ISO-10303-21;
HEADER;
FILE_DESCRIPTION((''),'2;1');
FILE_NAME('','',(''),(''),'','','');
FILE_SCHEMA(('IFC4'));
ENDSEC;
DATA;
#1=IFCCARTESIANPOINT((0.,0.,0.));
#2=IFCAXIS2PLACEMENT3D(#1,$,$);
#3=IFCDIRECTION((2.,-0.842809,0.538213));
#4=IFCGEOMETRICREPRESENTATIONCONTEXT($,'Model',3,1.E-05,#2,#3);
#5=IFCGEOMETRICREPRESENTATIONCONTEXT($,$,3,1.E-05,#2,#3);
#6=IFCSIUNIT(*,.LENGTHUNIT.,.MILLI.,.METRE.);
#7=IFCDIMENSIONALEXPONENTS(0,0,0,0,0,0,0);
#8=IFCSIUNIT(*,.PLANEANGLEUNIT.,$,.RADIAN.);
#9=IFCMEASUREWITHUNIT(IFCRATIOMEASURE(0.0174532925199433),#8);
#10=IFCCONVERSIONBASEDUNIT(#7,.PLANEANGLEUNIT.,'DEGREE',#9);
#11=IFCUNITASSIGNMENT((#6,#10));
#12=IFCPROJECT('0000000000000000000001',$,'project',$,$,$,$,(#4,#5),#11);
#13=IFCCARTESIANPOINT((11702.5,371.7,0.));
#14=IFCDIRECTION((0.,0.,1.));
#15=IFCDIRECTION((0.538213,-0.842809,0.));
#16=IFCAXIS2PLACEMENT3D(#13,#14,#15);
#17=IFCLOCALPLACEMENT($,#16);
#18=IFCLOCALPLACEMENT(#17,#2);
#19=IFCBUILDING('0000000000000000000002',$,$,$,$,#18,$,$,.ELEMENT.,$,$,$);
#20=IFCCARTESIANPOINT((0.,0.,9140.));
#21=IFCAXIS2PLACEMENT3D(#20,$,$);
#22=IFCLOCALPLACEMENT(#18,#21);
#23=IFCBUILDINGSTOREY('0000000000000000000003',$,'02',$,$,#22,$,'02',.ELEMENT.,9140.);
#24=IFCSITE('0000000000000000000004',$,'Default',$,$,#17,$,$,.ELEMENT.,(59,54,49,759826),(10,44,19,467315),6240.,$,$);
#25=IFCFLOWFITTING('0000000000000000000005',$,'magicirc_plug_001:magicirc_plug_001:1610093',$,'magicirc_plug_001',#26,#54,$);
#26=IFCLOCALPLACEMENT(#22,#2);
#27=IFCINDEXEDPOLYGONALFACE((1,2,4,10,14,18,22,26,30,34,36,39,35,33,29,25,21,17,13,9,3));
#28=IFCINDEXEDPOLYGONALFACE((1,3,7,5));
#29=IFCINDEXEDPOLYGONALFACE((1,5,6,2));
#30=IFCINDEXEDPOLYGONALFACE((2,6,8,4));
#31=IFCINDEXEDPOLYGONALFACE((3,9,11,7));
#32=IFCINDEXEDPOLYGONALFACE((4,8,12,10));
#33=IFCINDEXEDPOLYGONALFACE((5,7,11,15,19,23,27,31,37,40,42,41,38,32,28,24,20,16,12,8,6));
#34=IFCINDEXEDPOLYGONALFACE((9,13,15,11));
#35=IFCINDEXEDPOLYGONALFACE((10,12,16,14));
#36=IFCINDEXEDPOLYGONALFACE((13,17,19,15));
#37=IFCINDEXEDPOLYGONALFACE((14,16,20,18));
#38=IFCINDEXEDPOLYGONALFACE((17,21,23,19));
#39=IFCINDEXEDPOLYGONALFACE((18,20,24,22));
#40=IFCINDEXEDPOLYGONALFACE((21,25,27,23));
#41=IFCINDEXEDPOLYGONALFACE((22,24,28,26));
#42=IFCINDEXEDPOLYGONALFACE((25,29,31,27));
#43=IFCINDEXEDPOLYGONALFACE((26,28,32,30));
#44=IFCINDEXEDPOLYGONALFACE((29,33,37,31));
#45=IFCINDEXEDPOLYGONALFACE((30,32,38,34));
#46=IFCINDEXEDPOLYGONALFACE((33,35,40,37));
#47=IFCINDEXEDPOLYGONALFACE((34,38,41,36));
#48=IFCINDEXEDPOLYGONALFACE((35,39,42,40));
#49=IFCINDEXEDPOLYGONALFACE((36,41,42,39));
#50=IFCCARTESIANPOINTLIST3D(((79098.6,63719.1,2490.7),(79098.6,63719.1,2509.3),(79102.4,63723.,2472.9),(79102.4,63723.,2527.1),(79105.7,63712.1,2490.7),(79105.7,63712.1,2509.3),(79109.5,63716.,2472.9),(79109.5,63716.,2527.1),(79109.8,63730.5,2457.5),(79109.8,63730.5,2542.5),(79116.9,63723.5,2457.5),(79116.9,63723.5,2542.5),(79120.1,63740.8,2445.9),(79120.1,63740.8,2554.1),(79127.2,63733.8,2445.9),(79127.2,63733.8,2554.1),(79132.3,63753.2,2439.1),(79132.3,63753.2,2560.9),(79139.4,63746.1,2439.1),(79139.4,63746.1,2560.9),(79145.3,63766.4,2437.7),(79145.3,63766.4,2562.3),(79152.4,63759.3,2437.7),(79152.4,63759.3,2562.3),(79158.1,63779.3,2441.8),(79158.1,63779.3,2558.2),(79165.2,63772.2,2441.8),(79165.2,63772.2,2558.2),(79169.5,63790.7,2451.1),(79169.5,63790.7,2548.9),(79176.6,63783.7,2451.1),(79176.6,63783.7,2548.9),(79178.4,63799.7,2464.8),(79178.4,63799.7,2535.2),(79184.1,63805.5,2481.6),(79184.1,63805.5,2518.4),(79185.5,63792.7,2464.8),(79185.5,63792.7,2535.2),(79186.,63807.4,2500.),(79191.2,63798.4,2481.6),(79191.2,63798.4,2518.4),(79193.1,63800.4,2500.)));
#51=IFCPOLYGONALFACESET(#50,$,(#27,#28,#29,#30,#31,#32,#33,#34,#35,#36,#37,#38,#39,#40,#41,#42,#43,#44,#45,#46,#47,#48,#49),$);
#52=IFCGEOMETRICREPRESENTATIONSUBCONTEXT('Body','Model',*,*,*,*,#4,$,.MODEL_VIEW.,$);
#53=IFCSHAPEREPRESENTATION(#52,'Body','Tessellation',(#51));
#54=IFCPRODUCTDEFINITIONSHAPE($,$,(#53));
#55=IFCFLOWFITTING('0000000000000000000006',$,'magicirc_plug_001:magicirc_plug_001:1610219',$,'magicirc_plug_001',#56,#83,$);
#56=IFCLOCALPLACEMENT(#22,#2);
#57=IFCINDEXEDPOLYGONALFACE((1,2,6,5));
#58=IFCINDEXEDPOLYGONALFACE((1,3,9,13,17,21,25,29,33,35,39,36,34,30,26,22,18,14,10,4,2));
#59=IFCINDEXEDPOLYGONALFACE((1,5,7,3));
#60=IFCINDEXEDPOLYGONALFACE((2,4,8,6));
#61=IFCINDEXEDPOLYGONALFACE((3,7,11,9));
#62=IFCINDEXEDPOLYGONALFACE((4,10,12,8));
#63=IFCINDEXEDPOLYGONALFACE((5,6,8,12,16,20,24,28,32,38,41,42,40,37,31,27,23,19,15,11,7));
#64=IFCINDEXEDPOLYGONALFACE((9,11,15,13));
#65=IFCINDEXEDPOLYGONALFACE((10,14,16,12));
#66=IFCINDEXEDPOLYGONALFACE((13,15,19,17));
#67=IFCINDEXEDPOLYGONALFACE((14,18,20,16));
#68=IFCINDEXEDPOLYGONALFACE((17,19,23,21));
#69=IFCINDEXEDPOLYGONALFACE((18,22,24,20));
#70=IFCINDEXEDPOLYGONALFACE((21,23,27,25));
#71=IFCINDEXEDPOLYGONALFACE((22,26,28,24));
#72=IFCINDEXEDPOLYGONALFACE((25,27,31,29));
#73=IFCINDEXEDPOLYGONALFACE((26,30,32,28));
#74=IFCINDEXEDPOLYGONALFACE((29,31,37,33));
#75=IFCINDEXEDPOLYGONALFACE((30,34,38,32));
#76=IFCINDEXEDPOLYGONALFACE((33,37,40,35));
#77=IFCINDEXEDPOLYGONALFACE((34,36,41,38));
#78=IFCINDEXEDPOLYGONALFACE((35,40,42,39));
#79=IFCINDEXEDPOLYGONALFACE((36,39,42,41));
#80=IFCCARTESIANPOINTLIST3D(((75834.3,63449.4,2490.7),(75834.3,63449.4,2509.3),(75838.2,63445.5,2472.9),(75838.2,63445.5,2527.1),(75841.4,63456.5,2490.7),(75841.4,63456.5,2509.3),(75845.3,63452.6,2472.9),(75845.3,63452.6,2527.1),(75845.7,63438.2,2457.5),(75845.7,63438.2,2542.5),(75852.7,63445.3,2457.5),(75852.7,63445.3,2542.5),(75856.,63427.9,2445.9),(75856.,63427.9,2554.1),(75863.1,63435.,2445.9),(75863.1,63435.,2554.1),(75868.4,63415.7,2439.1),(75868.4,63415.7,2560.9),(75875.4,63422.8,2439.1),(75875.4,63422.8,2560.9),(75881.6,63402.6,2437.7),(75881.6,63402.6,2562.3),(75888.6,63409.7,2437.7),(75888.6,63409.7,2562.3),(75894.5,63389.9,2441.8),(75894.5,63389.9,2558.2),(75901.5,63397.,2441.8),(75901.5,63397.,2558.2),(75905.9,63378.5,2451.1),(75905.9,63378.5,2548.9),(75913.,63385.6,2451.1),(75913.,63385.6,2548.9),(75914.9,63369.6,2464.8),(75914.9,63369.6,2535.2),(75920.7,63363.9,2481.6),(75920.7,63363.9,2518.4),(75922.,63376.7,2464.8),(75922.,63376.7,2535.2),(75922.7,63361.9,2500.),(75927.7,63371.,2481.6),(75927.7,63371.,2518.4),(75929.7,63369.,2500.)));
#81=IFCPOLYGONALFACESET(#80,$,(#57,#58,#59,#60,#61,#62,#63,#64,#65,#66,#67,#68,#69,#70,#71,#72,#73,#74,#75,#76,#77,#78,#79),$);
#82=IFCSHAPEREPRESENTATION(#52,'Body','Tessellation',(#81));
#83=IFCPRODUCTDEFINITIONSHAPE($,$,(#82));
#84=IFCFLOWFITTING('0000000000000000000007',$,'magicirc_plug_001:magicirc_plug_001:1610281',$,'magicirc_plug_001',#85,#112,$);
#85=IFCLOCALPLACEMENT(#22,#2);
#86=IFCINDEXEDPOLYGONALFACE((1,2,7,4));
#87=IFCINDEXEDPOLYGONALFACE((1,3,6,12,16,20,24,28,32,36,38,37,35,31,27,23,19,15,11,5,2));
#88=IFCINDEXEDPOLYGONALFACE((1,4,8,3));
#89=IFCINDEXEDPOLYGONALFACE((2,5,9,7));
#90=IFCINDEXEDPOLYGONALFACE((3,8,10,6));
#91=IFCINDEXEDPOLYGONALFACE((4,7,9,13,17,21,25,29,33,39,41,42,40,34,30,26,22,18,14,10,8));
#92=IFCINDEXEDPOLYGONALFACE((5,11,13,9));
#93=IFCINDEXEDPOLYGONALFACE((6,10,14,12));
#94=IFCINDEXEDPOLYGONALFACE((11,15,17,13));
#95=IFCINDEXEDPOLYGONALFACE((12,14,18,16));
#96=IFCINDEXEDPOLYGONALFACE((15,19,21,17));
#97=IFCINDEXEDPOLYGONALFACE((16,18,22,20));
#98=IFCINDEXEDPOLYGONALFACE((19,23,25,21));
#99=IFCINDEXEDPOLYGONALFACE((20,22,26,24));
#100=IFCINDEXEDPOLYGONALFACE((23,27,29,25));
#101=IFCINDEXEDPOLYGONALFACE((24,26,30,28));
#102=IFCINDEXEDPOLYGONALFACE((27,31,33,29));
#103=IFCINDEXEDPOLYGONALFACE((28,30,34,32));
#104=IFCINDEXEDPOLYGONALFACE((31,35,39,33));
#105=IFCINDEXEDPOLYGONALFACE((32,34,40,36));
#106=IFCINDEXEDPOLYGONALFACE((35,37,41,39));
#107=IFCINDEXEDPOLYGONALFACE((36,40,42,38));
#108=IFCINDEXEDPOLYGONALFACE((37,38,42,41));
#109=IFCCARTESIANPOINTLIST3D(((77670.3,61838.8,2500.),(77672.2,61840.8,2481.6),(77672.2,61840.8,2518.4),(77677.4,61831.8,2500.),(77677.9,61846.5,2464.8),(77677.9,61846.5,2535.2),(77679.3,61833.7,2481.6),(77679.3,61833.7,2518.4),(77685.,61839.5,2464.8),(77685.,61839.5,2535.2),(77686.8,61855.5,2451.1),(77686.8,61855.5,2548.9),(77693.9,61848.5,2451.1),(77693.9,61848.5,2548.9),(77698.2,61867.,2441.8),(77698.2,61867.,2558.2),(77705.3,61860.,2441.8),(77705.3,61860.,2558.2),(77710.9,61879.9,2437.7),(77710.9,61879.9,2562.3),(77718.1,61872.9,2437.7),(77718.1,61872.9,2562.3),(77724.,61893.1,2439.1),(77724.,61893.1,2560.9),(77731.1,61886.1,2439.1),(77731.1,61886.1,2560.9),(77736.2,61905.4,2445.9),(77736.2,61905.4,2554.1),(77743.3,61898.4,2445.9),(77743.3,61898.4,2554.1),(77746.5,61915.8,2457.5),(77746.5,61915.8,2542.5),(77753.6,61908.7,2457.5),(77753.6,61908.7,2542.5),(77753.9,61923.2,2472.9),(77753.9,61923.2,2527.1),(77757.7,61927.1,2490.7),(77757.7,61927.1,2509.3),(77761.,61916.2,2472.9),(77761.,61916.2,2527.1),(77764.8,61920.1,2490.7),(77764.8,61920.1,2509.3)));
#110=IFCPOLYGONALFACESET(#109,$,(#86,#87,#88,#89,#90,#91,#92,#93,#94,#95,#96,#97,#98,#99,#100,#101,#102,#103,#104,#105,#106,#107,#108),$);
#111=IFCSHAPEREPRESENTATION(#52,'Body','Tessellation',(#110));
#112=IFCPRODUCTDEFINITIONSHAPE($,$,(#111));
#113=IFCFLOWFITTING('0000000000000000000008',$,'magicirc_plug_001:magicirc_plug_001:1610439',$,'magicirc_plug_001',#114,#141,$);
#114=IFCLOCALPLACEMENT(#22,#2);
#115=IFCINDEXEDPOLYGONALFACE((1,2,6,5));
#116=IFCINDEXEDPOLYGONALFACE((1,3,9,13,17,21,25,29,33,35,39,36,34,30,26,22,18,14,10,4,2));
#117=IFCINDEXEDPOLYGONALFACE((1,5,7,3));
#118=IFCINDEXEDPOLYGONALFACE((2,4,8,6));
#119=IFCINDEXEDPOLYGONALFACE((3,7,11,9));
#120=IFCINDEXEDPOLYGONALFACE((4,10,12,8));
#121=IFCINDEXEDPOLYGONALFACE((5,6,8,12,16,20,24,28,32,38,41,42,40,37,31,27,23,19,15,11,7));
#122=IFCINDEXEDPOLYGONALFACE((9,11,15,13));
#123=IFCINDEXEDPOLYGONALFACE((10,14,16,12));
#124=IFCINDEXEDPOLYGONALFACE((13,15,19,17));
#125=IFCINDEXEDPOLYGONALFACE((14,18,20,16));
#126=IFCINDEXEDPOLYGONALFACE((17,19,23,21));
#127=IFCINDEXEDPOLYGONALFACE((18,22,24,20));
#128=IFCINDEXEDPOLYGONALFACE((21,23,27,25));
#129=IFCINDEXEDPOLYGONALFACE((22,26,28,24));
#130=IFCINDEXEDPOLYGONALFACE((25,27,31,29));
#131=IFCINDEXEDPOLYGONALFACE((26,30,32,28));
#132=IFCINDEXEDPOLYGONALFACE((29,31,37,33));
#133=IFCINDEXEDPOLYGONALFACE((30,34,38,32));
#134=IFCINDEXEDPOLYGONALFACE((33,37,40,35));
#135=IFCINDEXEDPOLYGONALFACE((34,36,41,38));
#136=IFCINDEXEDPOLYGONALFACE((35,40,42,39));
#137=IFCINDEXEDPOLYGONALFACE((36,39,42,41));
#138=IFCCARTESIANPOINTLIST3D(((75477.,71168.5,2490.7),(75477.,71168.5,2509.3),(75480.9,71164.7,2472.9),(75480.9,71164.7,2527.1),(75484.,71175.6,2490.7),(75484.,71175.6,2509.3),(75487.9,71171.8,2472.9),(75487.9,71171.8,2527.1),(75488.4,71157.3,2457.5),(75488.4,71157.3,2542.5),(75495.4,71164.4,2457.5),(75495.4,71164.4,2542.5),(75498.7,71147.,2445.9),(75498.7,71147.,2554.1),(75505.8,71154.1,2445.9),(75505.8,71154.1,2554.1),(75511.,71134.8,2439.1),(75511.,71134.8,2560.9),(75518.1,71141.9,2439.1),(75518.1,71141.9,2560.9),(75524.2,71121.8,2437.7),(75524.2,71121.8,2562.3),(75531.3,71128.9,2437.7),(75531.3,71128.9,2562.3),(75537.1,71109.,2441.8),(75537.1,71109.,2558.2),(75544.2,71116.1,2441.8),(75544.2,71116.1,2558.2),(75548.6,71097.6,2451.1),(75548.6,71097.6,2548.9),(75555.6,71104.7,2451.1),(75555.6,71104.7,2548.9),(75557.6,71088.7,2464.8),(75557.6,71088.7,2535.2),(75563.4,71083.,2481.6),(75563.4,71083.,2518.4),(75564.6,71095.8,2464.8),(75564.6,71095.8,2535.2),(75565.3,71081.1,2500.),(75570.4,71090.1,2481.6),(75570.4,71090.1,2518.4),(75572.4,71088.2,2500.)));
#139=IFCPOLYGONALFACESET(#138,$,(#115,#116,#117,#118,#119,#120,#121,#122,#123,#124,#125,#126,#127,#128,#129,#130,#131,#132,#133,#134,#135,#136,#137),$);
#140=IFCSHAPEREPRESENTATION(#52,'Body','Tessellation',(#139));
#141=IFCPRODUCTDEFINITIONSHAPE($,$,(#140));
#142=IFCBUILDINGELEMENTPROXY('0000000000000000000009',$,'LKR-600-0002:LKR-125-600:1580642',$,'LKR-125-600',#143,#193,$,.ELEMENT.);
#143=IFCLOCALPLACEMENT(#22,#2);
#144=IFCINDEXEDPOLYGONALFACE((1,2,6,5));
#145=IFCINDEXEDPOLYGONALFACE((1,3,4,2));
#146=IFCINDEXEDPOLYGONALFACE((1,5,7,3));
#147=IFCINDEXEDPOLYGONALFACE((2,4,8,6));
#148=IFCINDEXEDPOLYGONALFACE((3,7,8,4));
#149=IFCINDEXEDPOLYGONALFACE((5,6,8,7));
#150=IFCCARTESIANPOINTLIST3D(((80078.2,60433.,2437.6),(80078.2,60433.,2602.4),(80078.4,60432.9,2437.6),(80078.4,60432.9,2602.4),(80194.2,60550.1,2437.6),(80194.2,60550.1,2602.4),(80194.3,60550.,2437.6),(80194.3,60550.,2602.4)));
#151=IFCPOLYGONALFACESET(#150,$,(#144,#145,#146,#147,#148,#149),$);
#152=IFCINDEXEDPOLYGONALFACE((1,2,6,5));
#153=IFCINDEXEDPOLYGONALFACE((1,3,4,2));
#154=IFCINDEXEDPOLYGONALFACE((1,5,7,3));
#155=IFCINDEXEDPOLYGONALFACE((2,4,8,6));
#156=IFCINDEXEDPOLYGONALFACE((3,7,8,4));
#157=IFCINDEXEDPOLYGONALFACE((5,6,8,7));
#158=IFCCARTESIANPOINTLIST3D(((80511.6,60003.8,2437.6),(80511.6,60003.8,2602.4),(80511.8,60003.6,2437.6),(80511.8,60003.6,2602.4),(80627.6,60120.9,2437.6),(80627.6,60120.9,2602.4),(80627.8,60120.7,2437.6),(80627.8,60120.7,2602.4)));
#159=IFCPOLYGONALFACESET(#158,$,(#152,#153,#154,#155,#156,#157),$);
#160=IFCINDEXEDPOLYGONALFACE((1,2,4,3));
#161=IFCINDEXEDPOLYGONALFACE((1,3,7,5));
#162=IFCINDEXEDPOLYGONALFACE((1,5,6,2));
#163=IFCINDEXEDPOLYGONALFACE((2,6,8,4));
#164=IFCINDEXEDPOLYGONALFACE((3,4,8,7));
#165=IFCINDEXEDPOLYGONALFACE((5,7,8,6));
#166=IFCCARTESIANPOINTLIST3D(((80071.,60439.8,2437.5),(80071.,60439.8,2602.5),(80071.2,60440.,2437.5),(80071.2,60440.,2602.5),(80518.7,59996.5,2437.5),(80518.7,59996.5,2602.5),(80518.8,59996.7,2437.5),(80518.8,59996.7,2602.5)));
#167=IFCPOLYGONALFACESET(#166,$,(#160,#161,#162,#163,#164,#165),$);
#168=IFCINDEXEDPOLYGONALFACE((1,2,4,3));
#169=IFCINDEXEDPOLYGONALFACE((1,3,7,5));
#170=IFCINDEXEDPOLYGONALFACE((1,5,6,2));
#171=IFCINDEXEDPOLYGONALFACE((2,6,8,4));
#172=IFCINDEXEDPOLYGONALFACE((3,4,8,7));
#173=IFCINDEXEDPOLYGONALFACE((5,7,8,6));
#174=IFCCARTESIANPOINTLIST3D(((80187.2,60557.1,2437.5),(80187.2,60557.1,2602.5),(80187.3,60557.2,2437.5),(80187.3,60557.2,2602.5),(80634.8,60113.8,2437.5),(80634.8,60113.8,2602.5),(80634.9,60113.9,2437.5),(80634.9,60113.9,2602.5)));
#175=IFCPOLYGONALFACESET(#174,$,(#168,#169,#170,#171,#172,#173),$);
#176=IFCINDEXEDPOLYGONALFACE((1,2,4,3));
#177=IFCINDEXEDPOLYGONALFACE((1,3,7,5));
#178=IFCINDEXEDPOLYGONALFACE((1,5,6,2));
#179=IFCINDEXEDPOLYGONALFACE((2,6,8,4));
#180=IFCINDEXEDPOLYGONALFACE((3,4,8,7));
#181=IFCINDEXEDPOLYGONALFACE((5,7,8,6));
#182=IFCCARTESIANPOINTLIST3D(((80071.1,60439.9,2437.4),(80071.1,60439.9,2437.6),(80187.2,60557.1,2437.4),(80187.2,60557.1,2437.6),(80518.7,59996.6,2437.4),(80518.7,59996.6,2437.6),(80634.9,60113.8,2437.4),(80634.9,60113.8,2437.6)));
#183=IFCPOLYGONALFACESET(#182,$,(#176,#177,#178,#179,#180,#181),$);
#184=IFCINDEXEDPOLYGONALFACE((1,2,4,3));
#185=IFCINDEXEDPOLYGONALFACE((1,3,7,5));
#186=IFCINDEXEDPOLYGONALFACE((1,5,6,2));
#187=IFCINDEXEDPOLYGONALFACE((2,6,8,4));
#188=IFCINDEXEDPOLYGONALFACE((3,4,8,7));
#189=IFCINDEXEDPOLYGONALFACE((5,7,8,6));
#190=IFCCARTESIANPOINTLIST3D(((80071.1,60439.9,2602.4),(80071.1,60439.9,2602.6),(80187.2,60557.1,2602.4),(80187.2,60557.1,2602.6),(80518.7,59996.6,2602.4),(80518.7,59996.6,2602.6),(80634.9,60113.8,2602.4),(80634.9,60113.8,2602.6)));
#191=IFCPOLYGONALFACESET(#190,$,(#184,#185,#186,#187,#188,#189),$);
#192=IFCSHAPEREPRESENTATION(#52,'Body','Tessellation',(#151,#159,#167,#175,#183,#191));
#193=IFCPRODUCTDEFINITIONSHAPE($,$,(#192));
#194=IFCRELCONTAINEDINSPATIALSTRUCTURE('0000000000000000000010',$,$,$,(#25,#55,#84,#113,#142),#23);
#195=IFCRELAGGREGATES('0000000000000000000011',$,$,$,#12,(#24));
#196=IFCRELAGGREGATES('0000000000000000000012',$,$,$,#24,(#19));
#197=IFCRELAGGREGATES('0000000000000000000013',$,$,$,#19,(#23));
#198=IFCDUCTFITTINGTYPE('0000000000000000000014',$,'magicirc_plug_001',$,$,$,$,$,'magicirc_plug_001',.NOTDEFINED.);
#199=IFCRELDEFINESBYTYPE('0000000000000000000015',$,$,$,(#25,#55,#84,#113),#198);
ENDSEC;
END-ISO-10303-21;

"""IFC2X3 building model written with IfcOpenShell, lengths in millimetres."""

from ifc_helpers import new_model, entity, si_unit, converted_unit, direction, frame, frame_2d, origin, place, context, subcontext, project, spatial, rectangle, circle, extrude, source, transform, mapped, type_object, type_shapes, element, save


model = new_model("IFC2X3")

# Units and contexts
model_context = context("Model", 3, precision=1e-05, world=origin(), true_north=direction((2.0, -0.842809, 0.538213)))
context_of_model = context(None, 3, precision=1e-05, world=origin(), true_north=direction((2.0, -0.842809, 0.538213)))
body_context = subcontext(model_context, "Body", "Model", "MODEL_VIEW")
ifc_project = project(units=[si_unit("LENGTHUNIT", "METRE", prefix="MILLI"), converted_unit("PLANEANGLEUNIT", "DEGREE", entity("IfcRatioMeasure", 0.0174532925199433), si_unit("PLANEANGLEUNIT", "RADIAN"), dimensions=[0, 0, 0, 0, 0, 0, 0])], contexts=[model_context, context_of_model])

# Site, building, storey
site_placement = place(None, frame((11702.5, 371.7, 0.0), z_axis=(0.0, 0.0, 1.0), x_axis=(0.538213, -0.842809, 0.0)))
site = spatial("IfcSite", under=ifc_project, at=site_placement, Name="Default", CompositionType="ELEMENT", RefLatitude=(59, 54, 49, 759826), RefLongitude=(10, 44, 19, 467315), RefElevation=6240.0)
building_placement = place(site_placement, origin())
building = spatial("IfcBuilding", under=site, at=building_placement, CompositionType="ELEMENT")
storey_placement = place(building_placement, frame((0.0, 0.0, 9140.0)))
storey = spatial("IfcBuildingStorey", under=building, at=storey_placement, Name="02", LongName="02", CompositionType="ELEMENT", Elevation=9140.0)

# Flow fittings
duct_fitting_type_1 = type_object("IfcDuctFittingType", Name="magicirc_plug_001", ElementType="magicirc_plug_001", PredefinedType="NOTDEFINED")
shared_shape_1 = source(origin(), body_context, "Body", "SweptSolid", [
    extrude(circle(Radius=62.5, at=frame_2d((0.0, 0.0), x_axis=(1.0, 0.0))), frame((0.0, 0.0, 0.0), z_axis=(1.0, 0.0, 0.0), x_axis=(0.0, 1.0, 0.0)), (0.0, 0.0, 1.0), 10.0),
])
type_shapes(duct_fitting_type_1, [shared_shape_1])
for number, where, z_axis, x_axis, name in (
    (1, (79142.1, 63763.0, 2500.0), (0.0, 0.0, 1.0), (0.710528, -0.703669, 0.0), "magicirc_plug_001:magicirc_plug_001:1610093"),
    (2, (75885.3, 63413.0, 2500.0), (0.0, 0.0, 1.0), (-0.703669, -0.710528, 0.0), "magicirc_plug_001:magicirc_plug_001:1610219"),
    (3, (77721.3, 61876.2, 2500.0), (0.0, 0.0, 1.0), (-0.710528, 0.703669, 0.0), "magicirc_plug_001:magicirc_plug_001:1610281"),
    (4, (75528.0, 71132.2, 2500.0), (0.0, 0.0, 1.0), (-0.703669, -0.710528, 0.0), "magicirc_plug_001:magicirc_plug_001:1610439"),
):
    element("IfcFlowFitting", number, at=place(storey_placement, frame(where, z_axis=z_axis, x_axis=x_axis)), inside=storey, type_object=duct_fitting_type_1, Name=name, ObjectType="magicirc_plug_001", context=body_context, shape_type="MappedRepresentation", body=[
        mapped(shared_shape_1, transform((0.0, 0.0, 0.0), scale=1.0)),
    ])

# Building element proxy
shared_shape_2 = source(origin(), body_context, "Body", "SweptSolid", [
    extrude(rectangle(XDim=0.2, YDim=164.8, at=frame_2d((0.0, 0.0), x_axis=(1.0, 0.0))), frame((305.0, 0.0, -82.4)), (0.0, 0.0, 1.0), 164.8),
    extrude(rectangle(XDim=0.2, YDim=164.8, at=frame_2d((0.0, 0.0), x_axis=(1.0, 0.0))), frame((-305.0, 0.0, -82.4)), (0.0, 0.0, 1.0), 164.8),
    extrude(rectangle(XDim=0.2, YDim=630.0, at=frame_2d((0.0, 0.0), x_axis=(1.0, 0.0))), frame((0.0, 82.5, -82.5), z_axis=(0.0, 0.0, 1.0), x_axis=(0.0, 1.0, 0.0)), (0.0, 0.0, 1.0), 165.0),
    extrude(rectangle(XDim=0.2, YDim=630.0, at=frame_2d((0.0, 0.0), x_axis=(1.0, 0.0))), frame((0.0, -82.5, -82.5), z_axis=(0.0, 0.0, 1.0), x_axis=(0.0, 1.0, 0.0)), (0.0, 0.0, 1.0), 165.0),
    extrude(rectangle(XDim=165.0, YDim=630.0, at=frame_2d((0.0, 0.0), x_axis=(1.0, 0.0))), frame((0.0, 0.0, -82.6), z_axis=(0.0, 0.0, 1.0), x_axis=(0.0, -1.0, 0.0)), (0.0, 0.0, 1.0), 0.2),
    extrude(rectangle(XDim=165.0, YDim=630.0, at=frame_2d((0.0, 0.0), x_axis=(1.0, 0.0))), frame((0.0, 0.0, 82.4), z_axis=(0.0, 0.0, 1.0), x_axis=(0.0, -1.0, 0.0)), (0.0, 0.0, 1.0), 0.2),
])
for number, where, z_axis, x_axis, name in (
    (5, (80353.0, 60276.9, 2520.0), (0.0, 0.0, 1.0), (-0.710528, 0.703669, 0.0), "LKR-600-0002:LKR-125-600:1580642"),
):
    element("IfcBuildingElementProxy", number, at=place(storey_placement, frame(where, z_axis=z_axis, x_axis=x_axis)), inside=storey, Name=name, ObjectType="LKR-125-600", CompositionType="ELEMENT", context=body_context, shape_type="MappedRepresentation", body=[
        mapped(shared_shape_2, transform((0.0, 0.0, 0.0), scale=1.0)),
    ])

save(model, "model.ifc")
